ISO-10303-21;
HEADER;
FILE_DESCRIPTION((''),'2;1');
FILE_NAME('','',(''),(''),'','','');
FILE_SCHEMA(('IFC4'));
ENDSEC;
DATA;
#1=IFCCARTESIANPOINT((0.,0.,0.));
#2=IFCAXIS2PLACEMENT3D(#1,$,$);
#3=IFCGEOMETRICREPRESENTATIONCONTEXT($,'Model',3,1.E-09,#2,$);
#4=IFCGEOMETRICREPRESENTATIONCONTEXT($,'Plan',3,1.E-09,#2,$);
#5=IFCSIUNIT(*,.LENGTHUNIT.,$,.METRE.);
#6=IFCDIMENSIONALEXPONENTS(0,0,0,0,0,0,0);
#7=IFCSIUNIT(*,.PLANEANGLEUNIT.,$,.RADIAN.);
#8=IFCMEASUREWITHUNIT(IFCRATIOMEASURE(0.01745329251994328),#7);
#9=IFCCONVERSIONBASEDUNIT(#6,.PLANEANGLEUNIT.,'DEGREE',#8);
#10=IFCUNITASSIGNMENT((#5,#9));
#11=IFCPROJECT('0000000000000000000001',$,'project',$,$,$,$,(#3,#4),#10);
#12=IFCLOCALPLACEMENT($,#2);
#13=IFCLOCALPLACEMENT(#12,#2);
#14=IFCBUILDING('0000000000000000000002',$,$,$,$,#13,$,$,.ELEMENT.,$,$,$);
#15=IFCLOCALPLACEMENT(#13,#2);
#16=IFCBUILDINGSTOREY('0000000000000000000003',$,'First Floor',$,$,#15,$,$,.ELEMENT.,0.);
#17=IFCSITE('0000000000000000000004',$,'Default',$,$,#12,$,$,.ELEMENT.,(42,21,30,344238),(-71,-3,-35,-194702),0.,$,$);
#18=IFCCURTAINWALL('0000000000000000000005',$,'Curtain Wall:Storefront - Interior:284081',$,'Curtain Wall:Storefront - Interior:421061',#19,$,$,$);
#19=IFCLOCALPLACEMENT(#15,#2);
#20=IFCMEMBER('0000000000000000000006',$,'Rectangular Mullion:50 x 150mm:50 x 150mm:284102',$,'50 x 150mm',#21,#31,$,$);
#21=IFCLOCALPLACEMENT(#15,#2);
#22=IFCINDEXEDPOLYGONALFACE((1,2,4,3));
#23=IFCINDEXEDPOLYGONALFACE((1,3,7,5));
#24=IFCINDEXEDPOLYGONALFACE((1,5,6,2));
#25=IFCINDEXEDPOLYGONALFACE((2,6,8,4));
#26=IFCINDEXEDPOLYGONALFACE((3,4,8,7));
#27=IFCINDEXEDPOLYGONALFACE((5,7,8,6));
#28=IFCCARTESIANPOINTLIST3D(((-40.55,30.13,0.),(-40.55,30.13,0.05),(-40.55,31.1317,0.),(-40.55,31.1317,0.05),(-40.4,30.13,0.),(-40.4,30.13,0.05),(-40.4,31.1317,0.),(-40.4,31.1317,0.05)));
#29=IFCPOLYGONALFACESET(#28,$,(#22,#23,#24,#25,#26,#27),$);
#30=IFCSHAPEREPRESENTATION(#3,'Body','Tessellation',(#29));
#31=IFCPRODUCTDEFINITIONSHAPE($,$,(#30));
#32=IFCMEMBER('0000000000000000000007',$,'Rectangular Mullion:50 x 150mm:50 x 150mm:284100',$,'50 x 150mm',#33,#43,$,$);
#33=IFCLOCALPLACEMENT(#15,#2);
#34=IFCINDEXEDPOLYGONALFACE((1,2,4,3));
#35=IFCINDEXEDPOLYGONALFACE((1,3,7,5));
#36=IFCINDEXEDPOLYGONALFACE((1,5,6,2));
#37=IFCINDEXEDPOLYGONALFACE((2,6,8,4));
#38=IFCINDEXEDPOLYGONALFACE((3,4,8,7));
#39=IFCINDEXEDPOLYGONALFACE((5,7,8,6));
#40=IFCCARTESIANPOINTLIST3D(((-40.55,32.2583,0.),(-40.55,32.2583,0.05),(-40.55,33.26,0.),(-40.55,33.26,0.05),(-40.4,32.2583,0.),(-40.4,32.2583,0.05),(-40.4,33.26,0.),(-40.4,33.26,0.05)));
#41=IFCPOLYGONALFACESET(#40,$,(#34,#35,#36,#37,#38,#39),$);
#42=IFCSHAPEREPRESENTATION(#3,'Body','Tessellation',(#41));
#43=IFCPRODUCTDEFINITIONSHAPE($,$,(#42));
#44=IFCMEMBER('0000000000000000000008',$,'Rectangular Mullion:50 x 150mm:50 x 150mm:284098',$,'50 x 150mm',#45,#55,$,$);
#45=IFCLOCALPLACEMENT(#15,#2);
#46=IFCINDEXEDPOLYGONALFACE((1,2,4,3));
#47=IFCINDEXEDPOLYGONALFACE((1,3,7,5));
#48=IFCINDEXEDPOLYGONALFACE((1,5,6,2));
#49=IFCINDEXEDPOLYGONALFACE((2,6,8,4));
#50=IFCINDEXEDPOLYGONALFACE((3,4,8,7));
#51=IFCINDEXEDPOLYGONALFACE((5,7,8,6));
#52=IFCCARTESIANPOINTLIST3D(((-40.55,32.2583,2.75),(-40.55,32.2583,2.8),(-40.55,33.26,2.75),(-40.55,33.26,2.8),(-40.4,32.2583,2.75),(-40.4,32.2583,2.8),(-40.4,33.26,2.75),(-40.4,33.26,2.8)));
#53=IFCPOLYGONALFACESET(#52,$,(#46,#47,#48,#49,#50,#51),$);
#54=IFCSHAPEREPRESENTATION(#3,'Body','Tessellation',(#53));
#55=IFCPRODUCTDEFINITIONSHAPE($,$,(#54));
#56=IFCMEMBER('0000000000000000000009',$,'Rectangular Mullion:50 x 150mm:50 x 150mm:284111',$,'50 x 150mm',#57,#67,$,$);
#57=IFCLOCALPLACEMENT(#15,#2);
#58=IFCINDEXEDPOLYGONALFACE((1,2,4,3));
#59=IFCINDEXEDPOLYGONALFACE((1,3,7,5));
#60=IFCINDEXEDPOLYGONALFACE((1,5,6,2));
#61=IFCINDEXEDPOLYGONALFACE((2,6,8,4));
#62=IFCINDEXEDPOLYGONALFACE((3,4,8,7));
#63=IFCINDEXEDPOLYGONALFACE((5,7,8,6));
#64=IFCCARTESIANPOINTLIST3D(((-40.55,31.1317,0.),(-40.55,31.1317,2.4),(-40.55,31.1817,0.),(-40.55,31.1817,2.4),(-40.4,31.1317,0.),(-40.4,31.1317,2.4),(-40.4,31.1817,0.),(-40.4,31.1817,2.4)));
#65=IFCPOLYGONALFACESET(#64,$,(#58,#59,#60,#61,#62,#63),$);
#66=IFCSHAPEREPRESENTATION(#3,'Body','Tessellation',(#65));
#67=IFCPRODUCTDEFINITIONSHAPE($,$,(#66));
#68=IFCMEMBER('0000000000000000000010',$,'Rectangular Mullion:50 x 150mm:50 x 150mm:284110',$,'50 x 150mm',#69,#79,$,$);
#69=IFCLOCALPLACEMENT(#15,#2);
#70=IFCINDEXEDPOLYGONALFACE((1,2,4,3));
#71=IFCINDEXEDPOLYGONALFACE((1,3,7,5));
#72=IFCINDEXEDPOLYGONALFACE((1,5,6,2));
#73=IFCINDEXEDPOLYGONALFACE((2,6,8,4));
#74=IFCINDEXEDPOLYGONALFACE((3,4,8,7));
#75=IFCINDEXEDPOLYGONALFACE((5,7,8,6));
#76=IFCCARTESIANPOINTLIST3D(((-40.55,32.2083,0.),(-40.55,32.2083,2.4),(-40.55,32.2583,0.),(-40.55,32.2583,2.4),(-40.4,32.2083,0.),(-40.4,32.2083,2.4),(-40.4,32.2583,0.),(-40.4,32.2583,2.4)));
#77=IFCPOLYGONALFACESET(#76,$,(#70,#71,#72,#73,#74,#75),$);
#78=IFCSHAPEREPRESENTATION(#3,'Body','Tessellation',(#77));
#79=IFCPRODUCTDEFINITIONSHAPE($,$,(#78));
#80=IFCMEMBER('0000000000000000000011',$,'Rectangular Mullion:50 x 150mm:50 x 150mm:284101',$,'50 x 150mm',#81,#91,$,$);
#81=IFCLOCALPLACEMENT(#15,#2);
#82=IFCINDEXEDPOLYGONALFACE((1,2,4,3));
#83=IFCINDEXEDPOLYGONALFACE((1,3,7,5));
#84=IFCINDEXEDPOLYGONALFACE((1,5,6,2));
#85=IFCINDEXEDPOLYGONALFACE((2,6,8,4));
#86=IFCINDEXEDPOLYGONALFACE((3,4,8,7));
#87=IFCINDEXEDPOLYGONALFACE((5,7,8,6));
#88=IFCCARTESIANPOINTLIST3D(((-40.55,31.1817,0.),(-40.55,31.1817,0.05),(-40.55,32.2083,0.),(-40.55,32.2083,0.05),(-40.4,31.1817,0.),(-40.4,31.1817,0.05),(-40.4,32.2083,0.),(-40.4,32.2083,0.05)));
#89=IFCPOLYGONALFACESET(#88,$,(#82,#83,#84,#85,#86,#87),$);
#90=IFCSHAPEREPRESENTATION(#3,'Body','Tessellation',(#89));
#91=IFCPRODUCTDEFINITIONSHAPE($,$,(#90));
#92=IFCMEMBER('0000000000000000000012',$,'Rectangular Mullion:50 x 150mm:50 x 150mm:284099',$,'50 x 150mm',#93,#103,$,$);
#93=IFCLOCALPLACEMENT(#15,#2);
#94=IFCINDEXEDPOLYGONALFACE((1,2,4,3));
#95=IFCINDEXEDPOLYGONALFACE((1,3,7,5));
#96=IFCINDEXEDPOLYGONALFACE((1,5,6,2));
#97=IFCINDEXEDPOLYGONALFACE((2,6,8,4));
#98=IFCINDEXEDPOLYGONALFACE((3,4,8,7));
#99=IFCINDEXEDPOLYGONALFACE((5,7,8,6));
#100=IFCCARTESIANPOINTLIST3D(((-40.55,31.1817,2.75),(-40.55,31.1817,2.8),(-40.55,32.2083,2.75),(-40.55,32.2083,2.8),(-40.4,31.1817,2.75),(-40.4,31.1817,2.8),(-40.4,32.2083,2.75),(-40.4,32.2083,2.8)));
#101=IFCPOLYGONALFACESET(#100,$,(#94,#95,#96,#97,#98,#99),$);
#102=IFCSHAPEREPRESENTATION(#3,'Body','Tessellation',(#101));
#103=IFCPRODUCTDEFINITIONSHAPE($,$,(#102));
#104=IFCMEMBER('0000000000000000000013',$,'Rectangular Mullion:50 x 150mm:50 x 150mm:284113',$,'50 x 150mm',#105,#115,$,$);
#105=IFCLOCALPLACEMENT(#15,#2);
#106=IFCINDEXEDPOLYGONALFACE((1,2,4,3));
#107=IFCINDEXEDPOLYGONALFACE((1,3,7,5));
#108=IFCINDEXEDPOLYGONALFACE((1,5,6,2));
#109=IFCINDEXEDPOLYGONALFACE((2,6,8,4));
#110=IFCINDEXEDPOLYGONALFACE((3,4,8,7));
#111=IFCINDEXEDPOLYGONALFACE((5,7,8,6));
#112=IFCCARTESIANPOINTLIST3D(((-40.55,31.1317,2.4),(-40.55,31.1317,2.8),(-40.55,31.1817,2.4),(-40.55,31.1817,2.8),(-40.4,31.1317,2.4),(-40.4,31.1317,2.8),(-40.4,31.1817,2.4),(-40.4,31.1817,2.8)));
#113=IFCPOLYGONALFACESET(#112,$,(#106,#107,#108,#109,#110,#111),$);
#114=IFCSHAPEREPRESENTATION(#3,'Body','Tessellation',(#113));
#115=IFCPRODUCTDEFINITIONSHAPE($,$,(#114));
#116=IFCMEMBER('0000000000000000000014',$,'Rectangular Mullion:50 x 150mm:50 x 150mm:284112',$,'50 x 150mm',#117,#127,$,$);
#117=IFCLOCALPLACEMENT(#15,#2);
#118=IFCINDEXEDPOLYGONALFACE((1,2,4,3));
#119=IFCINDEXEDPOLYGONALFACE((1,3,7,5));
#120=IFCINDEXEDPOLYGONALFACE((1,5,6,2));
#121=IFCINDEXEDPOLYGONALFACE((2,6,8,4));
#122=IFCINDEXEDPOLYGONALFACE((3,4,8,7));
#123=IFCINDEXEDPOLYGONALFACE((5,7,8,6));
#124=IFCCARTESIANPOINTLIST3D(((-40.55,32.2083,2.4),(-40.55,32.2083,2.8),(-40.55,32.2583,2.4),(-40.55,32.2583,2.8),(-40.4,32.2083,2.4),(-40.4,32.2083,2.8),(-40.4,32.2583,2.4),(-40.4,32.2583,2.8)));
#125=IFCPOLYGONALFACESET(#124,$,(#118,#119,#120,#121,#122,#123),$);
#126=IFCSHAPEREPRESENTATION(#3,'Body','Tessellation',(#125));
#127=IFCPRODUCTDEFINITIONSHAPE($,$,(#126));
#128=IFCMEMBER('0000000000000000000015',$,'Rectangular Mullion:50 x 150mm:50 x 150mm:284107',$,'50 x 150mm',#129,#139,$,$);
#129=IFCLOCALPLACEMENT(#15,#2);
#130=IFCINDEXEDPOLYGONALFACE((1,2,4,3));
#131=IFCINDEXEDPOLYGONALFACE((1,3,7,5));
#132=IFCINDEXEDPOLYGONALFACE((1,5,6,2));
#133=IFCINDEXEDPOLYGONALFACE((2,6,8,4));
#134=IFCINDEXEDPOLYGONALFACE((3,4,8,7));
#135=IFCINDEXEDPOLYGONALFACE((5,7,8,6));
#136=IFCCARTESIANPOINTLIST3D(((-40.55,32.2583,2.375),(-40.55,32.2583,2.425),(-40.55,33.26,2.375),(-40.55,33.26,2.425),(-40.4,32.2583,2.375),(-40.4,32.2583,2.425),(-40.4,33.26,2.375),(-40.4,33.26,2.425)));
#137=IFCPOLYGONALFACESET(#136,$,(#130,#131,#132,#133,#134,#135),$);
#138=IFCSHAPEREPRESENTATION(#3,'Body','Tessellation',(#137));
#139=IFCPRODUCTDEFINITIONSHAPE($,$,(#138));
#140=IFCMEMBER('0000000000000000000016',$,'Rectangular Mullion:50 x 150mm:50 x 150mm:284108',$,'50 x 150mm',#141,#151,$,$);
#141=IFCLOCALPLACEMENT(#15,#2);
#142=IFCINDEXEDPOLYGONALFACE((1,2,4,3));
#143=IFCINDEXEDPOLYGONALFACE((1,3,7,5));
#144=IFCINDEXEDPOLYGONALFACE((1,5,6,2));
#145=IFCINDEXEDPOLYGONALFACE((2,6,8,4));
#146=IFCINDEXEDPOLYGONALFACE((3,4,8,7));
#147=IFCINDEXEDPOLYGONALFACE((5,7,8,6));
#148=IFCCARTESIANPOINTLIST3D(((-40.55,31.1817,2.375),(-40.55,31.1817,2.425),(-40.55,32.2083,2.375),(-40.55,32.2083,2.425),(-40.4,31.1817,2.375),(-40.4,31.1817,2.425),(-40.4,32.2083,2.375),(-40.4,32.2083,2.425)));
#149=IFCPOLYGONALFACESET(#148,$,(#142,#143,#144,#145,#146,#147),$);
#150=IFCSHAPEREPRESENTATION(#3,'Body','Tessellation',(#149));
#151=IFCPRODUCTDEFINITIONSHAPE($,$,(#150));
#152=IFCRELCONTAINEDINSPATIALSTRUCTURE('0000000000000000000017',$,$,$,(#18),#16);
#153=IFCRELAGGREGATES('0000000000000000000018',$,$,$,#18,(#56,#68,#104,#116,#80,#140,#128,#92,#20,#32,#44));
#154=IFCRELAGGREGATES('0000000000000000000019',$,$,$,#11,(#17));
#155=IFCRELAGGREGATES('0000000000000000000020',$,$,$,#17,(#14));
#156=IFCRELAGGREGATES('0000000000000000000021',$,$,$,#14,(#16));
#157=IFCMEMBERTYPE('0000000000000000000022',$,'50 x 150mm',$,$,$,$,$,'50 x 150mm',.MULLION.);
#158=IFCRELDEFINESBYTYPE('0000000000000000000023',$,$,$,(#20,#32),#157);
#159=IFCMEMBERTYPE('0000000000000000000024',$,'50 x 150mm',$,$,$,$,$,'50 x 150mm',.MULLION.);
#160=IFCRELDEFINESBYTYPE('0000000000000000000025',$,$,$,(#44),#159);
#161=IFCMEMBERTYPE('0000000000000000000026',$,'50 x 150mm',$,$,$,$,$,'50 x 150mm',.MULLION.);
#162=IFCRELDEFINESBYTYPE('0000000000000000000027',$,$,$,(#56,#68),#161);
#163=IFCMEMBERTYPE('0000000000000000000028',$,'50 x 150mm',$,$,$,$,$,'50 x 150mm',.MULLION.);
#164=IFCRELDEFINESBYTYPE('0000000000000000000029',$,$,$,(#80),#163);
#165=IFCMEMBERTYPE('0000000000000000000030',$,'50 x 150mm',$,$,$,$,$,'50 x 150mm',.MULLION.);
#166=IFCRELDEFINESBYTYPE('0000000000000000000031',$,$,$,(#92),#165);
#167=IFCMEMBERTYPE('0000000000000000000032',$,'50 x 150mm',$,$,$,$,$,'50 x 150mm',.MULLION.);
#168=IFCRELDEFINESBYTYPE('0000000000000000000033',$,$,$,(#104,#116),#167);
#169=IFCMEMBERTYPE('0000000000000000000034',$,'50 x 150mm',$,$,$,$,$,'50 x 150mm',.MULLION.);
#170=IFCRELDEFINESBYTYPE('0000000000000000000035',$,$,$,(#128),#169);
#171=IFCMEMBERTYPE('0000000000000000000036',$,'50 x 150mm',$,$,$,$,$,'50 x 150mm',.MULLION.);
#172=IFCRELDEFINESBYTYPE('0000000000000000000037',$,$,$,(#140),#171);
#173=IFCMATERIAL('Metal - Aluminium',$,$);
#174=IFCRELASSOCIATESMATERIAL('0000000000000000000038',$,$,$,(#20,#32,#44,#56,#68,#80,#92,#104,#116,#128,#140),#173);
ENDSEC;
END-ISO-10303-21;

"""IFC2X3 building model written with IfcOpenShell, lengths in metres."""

from ifc_helpers import new_model, entity, si_unit, converted_unit, frame, origin, origin_2d_with_axis, place, context, project, spatial, rectangle, extrude, source, transform, mapped, material, type_object, type_shapes, element, aggregate, save


model = new_model("IFC2X3")

# Units and contexts
model_context = context("Model", 3, precision=1e-09, world=origin())
plan_context = context("Plan", 3, precision=1e-09, world=origin())
ifc_project = project(units=[si_unit("LENGTHUNIT", "METRE"), converted_unit("PLANEANGLEUNIT", "DEGREE", entity("IfcRatioMeasure", 0.01745329251994328), si_unit("PLANEANGLEUNIT", "RADIAN"), dimensions=[0, 0, 0, 0, 0, 0, 0])], contexts=[model_context, plan_context])

# Site, building, storey
site_placement = place(None, origin())
site = spatial("IfcSite", under=ifc_project, at=site_placement, Name="Default", CompositionType="ELEMENT", RefLatitude=(42, 21, 30, 344238), RefLongitude=(-71, -3, -35, -194702), RefElevation=0.0)
building_placement = place(site_placement, origin())
building = spatial("IfcBuilding", under=site, at=building_placement, CompositionType="ELEMENT")
storey_placement = place(building_placement, origin())
storey = spatial("IfcBuildingStorey", under=building, at=storey_placement, Name="First Floor", CompositionType="ELEMENT", Elevation=0.0)

# Curtain wall, members
curtain_wall_placement = place(storey_placement, origin())
curtain_wall = element("IfcCurtainWall", 1, at=curtain_wall_placement, inside=storey, Name="Curtain Wall:Storefront - Interior:284081", ObjectType="Curtain Wall:Storefront - Interior:421061")
ifc_material_1 = material(Name="Metal - Aluminium")
member_type_1 = type_object("IfcMemberType", Name="50 x 150mm", ElementType="50 x 150mm", PredefinedType="MULLION")
shared_shape_1 = source(origin(), model_context, "Body", "SweptSolid", [
    extrude(rectangle(XDim=0.05, YDim=0.15, at=origin_2d_with_axis()), frame((-0.025, 0.0, -1.0017), z_axis=(0.0, 0.0, 1.0), x_axis=(-1.0, 0.0, 0.0)), (0.0, 0.0, 1.0), 1.0017),
])
type_shapes(member_type_1, [shared_shape_1])
member_1_placement = place(storey_placement, frame((-40.475, 31.1317, 0.0), z_axis=(0.0, 1.0, 0.0), x_axis=(0.0, 0.0, -1.0)))
member_1 = element("IfcMember", 2, at=member_1_placement, type_object=member_type_1, material=ifc_material_1, Name="Rectangular Mullion:50 x 150mm:50 x 150mm:284102", ObjectType="50 x 150mm", context=model_context, shape_type="MappedRepresentation", body=[
    mapped(shared_shape_1, transform((0.0, 0.0, 0.0), scale=1.0)),
])
member_2_placement = place(storey_placement, frame((-40.475, 33.26, 0.0), z_axis=(0.0, 1.0, 0.0), x_axis=(0.0, 0.0, -1.0)))
member_2 = element("IfcMember", 3, at=member_2_placement, type_object=member_type_1, material=ifc_material_1, Name="Rectangular Mullion:50 x 150mm:50 x 150mm:284100", ObjectType="50 x 150mm", context=model_context, shape_type="MappedRepresentation", body=[
    mapped(shared_shape_1, transform((0.0, 0.0, 0.0), scale=1.0)),
])
member_type_2 = type_object("IfcMemberType", Name="50 x 150mm", ElementType="50 x 150mm", PredefinedType="MULLION")
type_shapes(member_type_2, [shared_shape_1])
member_3_placement = place(storey_placement, frame((-40.475, 32.2583, 2.8), z_axis=(0.0, -1.0, 0.0), x_axis=(0.0, 0.0, 1.0)))
member_3 = element("IfcMember", 4, at=member_3_placement, type_object=member_type_2, material=ifc_material_1, Name="Rectangular Mullion:50 x 150mm:50 x 150mm:284098", ObjectType="50 x 150mm", context=model_context, shape_type="MappedRepresentation", body=[
    mapped(shared_shape_1, transform((0.0, 0.0, 0.0), scale=1.0)),
])
member_type_3 = type_object("IfcMemberType", Name="50 x 150mm", ElementType="50 x 150mm", PredefinedType="MULLION")
shared_shape_2 = source(origin(), model_context, "Body", "SweptSolid", [
    extrude(rectangle(XDim=0.05, YDim=0.15, at=origin_2d_with_axis()), frame((0.0, 0.0, -2.4), z_axis=(0.0, 0.0, 1.0), x_axis=(-1.0, 0.0, 0.0)), (0.0, 0.0, 1.0), 2.4),
])
type_shapes(member_type_3, [shared_shape_2])
member_4_placement = place(storey_placement, frame((-40.475, 31.1567, 0.0), z_axis=(0.0, 0.0, -1.0), x_axis=(0.0, -1.0, 0.0)))
member_4 = element("IfcMember", 5, at=member_4_placement, type_object=member_type_3, material=ifc_material_1, Name="Rectangular Mullion:50 x 150mm:50 x 150mm:284111", ObjectType="50 x 150mm", context=model_context, shape_type="MappedRepresentation", body=[
    mapped(shared_shape_2, transform((0.0, 0.0, 0.0), scale=1.0)),
])
member_5_placement = place(storey_placement, frame((-40.475, 32.2333, 0.0), z_axis=(0.0, 0.0, -1.0), x_axis=(0.0, -1.0, 0.0)))
member_5 = element("IfcMember", 6, at=member_5_placement, type_object=member_type_3, material=ifc_material_1, Name="Rectangular Mullion:50 x 150mm:50 x 150mm:284110", ObjectType="50 x 150mm", context=model_context, shape_type="MappedRepresentation", body=[
    mapped(shared_shape_2, transform((0.0, 0.0, 0.0), scale=1.0)),
])
member_type_4 = type_object("IfcMemberType", Name="50 x 150mm", ElementType="50 x 150mm", PredefinedType="MULLION")
shared_shape_3 = source(origin(), model_context, "Body", "SweptSolid", [
    extrude(rectangle(XDim=0.05, YDim=0.15, at=origin_2d_with_axis()), frame((-0.025, 0.0, -1.0267), z_axis=(0.0, 0.0, 1.0), x_axis=(-1.0, 0.0, 0.0)), (0.0, 0.0, 1.0), 1.0267),
])
type_shapes(member_type_4, [shared_shape_3])
member_6_placement = place(storey_placement, frame((-40.475, 32.2083, 0.0), z_axis=(0.0, 1.0, 0.0), x_axis=(0.0, 0.0, -1.0)))
member_6 = element("IfcMember", 7, at=member_6_placement, type_object=member_type_4, material=ifc_material_1, Name="Rectangular Mullion:50 x 150mm:50 x 150mm:284101", ObjectType="50 x 150mm", context=model_context, shape_type="MappedRepresentation", body=[
    mapped(shared_shape_3, transform((0.0, 0.0, 0.0), scale=1.0)),
])
member_type_5 = type_object("IfcMemberType", Name="50 x 150mm", ElementType="50 x 150mm", PredefinedType="MULLION")
type_shapes(member_type_5, [shared_shape_3])
member_7_placement = place(storey_placement, frame((-40.475, 31.1817, 2.8), z_axis=(0.0, -1.0, 0.0), x_axis=(0.0, 0.0, 1.0)))
member_7 = element("IfcMember", 8, at=member_7_placement, type_object=member_type_5, material=ifc_material_1, Name="Rectangular Mullion:50 x 150mm:50 x 150mm:284099", ObjectType="50 x 150mm", context=model_context, shape_type="MappedRepresentation", body=[
    mapped(shared_shape_3, transform((0.0, 0.0, 0.0), scale=1.0)),
])
member_type_6 = type_object("IfcMemberType", Name="50 x 150mm", ElementType="50 x 150mm", PredefinedType="MULLION")
shared_shape_4 = source(origin(), model_context, "Body", "SweptSolid", [
    extrude(rectangle(XDim=0.05, YDim=0.15, at=origin_2d_with_axis()), frame((0.0, 0.0, -0.4), z_axis=(0.0, 0.0, 1.0), x_axis=(-1.0, 0.0, 0.0)), (0.0, 0.0, 1.0), 0.4),
])
type_shapes(member_type_6, [shared_shape_4])
member_8_placement = place(storey_placement, frame((-40.475, 31.1567, 2.4), z_axis=(0.0, 0.0, -1.0), x_axis=(0.0, -1.0, 0.0)))
member_8 = element("IfcMember", 9, at=member_8_placement, type_object=member_type_6, material=ifc_material_1, Name="Rectangular Mullion:50 x 150mm:50 x 150mm:284113", ObjectType="50 x 150mm", context=model_context, shape_type="MappedRepresentation", body=[
    mapped(shared_shape_4, transform((0.0, 0.0, 0.0), scale=1.0)),
])
member_9_placement = place(storey_placement, frame((-40.475, 32.2333, 2.4), z_axis=(0.0, 0.0, -1.0), x_axis=(0.0, -1.0, 0.0)))
member_9 = element("IfcMember", 10, at=member_9_placement, type_object=member_type_6, material=ifc_material_1, Name="Rectangular Mullion:50 x 150mm:50 x 150mm:284112", ObjectType="50 x 150mm", context=model_context, shape_type="MappedRepresentation", body=[
    mapped(shared_shape_4, transform((0.0, 0.0, 0.0), scale=1.0)),
])
member_type_7 = type_object("IfcMemberType", Name="50 x 150mm", ElementType="50 x 150mm", PredefinedType="MULLION")
shared_shape_5 = source(origin(), model_context, "Body", "SweptSolid", [
    extrude(rectangle(XDim=0.05, YDim=0.15, at=origin_2d_with_axis()), frame((0.0, 0.0, -1.0017), z_axis=(0.0, 0.0, 1.0), x_axis=(-1.0, 0.0, 0.0)), (0.0, 0.0, 1.0), 1.0017),
])
type_shapes(member_type_7, [shared_shape_5])
member_10_placement = place(storey_placement, frame((-40.475, 32.2583, 2.4), z_axis=(0.0, -1.0, 0.0), x_axis=(0.0, 0.0, 1.0)))
member_10 = element("IfcMember", 11, at=member_10_placement, type_object=member_type_7, material=ifc_material_1, Name="Rectangular Mullion:50 x 150mm:50 x 150mm:284107", ObjectType="50 x 150mm", context=model_context, shape_type="MappedRepresentation", body=[
    mapped(shared_shape_5, transform((0.0, 0.0, 0.0), scale=1.0)),
])
member_type_8 = type_object("IfcMemberType", Name="50 x 150mm", ElementType="50 x 150mm", PredefinedType="MULLION")
shared_shape_6 = source(origin(), model_context, "Body", "SweptSolid", [
    extrude(rectangle(XDim=0.05, YDim=0.15, at=origin_2d_with_axis()), frame((0.0, 0.0, -1.0267), z_axis=(0.0, 0.0, 1.0), x_axis=(-1.0, 0.0, 0.0)), (0.0, 0.0, 1.0), 1.0267),
])
type_shapes(member_type_8, [shared_shape_6])
member_11_placement = place(storey_placement, frame((-40.475, 31.1817, 2.4), z_axis=(0.0, -1.0, 0.0), x_axis=(0.0, 0.0, 1.0)))
member_11 = element("IfcMember", 12, at=member_11_placement, type_object=member_type_8, material=ifc_material_1, Name="Rectangular Mullion:50 x 150mm:50 x 150mm:284108", ObjectType="50 x 150mm", context=model_context, shape_type="MappedRepresentation", body=[
    mapped(shared_shape_6, transform((0.0, 0.0, 0.0), scale=1.0)),
])
aggregate(curtain_wall, [member_4, member_5, member_8, member_9, member_6, member_11, member_10, member_7, member_1, member_2, member_3])

save(model, "model.ifc")
